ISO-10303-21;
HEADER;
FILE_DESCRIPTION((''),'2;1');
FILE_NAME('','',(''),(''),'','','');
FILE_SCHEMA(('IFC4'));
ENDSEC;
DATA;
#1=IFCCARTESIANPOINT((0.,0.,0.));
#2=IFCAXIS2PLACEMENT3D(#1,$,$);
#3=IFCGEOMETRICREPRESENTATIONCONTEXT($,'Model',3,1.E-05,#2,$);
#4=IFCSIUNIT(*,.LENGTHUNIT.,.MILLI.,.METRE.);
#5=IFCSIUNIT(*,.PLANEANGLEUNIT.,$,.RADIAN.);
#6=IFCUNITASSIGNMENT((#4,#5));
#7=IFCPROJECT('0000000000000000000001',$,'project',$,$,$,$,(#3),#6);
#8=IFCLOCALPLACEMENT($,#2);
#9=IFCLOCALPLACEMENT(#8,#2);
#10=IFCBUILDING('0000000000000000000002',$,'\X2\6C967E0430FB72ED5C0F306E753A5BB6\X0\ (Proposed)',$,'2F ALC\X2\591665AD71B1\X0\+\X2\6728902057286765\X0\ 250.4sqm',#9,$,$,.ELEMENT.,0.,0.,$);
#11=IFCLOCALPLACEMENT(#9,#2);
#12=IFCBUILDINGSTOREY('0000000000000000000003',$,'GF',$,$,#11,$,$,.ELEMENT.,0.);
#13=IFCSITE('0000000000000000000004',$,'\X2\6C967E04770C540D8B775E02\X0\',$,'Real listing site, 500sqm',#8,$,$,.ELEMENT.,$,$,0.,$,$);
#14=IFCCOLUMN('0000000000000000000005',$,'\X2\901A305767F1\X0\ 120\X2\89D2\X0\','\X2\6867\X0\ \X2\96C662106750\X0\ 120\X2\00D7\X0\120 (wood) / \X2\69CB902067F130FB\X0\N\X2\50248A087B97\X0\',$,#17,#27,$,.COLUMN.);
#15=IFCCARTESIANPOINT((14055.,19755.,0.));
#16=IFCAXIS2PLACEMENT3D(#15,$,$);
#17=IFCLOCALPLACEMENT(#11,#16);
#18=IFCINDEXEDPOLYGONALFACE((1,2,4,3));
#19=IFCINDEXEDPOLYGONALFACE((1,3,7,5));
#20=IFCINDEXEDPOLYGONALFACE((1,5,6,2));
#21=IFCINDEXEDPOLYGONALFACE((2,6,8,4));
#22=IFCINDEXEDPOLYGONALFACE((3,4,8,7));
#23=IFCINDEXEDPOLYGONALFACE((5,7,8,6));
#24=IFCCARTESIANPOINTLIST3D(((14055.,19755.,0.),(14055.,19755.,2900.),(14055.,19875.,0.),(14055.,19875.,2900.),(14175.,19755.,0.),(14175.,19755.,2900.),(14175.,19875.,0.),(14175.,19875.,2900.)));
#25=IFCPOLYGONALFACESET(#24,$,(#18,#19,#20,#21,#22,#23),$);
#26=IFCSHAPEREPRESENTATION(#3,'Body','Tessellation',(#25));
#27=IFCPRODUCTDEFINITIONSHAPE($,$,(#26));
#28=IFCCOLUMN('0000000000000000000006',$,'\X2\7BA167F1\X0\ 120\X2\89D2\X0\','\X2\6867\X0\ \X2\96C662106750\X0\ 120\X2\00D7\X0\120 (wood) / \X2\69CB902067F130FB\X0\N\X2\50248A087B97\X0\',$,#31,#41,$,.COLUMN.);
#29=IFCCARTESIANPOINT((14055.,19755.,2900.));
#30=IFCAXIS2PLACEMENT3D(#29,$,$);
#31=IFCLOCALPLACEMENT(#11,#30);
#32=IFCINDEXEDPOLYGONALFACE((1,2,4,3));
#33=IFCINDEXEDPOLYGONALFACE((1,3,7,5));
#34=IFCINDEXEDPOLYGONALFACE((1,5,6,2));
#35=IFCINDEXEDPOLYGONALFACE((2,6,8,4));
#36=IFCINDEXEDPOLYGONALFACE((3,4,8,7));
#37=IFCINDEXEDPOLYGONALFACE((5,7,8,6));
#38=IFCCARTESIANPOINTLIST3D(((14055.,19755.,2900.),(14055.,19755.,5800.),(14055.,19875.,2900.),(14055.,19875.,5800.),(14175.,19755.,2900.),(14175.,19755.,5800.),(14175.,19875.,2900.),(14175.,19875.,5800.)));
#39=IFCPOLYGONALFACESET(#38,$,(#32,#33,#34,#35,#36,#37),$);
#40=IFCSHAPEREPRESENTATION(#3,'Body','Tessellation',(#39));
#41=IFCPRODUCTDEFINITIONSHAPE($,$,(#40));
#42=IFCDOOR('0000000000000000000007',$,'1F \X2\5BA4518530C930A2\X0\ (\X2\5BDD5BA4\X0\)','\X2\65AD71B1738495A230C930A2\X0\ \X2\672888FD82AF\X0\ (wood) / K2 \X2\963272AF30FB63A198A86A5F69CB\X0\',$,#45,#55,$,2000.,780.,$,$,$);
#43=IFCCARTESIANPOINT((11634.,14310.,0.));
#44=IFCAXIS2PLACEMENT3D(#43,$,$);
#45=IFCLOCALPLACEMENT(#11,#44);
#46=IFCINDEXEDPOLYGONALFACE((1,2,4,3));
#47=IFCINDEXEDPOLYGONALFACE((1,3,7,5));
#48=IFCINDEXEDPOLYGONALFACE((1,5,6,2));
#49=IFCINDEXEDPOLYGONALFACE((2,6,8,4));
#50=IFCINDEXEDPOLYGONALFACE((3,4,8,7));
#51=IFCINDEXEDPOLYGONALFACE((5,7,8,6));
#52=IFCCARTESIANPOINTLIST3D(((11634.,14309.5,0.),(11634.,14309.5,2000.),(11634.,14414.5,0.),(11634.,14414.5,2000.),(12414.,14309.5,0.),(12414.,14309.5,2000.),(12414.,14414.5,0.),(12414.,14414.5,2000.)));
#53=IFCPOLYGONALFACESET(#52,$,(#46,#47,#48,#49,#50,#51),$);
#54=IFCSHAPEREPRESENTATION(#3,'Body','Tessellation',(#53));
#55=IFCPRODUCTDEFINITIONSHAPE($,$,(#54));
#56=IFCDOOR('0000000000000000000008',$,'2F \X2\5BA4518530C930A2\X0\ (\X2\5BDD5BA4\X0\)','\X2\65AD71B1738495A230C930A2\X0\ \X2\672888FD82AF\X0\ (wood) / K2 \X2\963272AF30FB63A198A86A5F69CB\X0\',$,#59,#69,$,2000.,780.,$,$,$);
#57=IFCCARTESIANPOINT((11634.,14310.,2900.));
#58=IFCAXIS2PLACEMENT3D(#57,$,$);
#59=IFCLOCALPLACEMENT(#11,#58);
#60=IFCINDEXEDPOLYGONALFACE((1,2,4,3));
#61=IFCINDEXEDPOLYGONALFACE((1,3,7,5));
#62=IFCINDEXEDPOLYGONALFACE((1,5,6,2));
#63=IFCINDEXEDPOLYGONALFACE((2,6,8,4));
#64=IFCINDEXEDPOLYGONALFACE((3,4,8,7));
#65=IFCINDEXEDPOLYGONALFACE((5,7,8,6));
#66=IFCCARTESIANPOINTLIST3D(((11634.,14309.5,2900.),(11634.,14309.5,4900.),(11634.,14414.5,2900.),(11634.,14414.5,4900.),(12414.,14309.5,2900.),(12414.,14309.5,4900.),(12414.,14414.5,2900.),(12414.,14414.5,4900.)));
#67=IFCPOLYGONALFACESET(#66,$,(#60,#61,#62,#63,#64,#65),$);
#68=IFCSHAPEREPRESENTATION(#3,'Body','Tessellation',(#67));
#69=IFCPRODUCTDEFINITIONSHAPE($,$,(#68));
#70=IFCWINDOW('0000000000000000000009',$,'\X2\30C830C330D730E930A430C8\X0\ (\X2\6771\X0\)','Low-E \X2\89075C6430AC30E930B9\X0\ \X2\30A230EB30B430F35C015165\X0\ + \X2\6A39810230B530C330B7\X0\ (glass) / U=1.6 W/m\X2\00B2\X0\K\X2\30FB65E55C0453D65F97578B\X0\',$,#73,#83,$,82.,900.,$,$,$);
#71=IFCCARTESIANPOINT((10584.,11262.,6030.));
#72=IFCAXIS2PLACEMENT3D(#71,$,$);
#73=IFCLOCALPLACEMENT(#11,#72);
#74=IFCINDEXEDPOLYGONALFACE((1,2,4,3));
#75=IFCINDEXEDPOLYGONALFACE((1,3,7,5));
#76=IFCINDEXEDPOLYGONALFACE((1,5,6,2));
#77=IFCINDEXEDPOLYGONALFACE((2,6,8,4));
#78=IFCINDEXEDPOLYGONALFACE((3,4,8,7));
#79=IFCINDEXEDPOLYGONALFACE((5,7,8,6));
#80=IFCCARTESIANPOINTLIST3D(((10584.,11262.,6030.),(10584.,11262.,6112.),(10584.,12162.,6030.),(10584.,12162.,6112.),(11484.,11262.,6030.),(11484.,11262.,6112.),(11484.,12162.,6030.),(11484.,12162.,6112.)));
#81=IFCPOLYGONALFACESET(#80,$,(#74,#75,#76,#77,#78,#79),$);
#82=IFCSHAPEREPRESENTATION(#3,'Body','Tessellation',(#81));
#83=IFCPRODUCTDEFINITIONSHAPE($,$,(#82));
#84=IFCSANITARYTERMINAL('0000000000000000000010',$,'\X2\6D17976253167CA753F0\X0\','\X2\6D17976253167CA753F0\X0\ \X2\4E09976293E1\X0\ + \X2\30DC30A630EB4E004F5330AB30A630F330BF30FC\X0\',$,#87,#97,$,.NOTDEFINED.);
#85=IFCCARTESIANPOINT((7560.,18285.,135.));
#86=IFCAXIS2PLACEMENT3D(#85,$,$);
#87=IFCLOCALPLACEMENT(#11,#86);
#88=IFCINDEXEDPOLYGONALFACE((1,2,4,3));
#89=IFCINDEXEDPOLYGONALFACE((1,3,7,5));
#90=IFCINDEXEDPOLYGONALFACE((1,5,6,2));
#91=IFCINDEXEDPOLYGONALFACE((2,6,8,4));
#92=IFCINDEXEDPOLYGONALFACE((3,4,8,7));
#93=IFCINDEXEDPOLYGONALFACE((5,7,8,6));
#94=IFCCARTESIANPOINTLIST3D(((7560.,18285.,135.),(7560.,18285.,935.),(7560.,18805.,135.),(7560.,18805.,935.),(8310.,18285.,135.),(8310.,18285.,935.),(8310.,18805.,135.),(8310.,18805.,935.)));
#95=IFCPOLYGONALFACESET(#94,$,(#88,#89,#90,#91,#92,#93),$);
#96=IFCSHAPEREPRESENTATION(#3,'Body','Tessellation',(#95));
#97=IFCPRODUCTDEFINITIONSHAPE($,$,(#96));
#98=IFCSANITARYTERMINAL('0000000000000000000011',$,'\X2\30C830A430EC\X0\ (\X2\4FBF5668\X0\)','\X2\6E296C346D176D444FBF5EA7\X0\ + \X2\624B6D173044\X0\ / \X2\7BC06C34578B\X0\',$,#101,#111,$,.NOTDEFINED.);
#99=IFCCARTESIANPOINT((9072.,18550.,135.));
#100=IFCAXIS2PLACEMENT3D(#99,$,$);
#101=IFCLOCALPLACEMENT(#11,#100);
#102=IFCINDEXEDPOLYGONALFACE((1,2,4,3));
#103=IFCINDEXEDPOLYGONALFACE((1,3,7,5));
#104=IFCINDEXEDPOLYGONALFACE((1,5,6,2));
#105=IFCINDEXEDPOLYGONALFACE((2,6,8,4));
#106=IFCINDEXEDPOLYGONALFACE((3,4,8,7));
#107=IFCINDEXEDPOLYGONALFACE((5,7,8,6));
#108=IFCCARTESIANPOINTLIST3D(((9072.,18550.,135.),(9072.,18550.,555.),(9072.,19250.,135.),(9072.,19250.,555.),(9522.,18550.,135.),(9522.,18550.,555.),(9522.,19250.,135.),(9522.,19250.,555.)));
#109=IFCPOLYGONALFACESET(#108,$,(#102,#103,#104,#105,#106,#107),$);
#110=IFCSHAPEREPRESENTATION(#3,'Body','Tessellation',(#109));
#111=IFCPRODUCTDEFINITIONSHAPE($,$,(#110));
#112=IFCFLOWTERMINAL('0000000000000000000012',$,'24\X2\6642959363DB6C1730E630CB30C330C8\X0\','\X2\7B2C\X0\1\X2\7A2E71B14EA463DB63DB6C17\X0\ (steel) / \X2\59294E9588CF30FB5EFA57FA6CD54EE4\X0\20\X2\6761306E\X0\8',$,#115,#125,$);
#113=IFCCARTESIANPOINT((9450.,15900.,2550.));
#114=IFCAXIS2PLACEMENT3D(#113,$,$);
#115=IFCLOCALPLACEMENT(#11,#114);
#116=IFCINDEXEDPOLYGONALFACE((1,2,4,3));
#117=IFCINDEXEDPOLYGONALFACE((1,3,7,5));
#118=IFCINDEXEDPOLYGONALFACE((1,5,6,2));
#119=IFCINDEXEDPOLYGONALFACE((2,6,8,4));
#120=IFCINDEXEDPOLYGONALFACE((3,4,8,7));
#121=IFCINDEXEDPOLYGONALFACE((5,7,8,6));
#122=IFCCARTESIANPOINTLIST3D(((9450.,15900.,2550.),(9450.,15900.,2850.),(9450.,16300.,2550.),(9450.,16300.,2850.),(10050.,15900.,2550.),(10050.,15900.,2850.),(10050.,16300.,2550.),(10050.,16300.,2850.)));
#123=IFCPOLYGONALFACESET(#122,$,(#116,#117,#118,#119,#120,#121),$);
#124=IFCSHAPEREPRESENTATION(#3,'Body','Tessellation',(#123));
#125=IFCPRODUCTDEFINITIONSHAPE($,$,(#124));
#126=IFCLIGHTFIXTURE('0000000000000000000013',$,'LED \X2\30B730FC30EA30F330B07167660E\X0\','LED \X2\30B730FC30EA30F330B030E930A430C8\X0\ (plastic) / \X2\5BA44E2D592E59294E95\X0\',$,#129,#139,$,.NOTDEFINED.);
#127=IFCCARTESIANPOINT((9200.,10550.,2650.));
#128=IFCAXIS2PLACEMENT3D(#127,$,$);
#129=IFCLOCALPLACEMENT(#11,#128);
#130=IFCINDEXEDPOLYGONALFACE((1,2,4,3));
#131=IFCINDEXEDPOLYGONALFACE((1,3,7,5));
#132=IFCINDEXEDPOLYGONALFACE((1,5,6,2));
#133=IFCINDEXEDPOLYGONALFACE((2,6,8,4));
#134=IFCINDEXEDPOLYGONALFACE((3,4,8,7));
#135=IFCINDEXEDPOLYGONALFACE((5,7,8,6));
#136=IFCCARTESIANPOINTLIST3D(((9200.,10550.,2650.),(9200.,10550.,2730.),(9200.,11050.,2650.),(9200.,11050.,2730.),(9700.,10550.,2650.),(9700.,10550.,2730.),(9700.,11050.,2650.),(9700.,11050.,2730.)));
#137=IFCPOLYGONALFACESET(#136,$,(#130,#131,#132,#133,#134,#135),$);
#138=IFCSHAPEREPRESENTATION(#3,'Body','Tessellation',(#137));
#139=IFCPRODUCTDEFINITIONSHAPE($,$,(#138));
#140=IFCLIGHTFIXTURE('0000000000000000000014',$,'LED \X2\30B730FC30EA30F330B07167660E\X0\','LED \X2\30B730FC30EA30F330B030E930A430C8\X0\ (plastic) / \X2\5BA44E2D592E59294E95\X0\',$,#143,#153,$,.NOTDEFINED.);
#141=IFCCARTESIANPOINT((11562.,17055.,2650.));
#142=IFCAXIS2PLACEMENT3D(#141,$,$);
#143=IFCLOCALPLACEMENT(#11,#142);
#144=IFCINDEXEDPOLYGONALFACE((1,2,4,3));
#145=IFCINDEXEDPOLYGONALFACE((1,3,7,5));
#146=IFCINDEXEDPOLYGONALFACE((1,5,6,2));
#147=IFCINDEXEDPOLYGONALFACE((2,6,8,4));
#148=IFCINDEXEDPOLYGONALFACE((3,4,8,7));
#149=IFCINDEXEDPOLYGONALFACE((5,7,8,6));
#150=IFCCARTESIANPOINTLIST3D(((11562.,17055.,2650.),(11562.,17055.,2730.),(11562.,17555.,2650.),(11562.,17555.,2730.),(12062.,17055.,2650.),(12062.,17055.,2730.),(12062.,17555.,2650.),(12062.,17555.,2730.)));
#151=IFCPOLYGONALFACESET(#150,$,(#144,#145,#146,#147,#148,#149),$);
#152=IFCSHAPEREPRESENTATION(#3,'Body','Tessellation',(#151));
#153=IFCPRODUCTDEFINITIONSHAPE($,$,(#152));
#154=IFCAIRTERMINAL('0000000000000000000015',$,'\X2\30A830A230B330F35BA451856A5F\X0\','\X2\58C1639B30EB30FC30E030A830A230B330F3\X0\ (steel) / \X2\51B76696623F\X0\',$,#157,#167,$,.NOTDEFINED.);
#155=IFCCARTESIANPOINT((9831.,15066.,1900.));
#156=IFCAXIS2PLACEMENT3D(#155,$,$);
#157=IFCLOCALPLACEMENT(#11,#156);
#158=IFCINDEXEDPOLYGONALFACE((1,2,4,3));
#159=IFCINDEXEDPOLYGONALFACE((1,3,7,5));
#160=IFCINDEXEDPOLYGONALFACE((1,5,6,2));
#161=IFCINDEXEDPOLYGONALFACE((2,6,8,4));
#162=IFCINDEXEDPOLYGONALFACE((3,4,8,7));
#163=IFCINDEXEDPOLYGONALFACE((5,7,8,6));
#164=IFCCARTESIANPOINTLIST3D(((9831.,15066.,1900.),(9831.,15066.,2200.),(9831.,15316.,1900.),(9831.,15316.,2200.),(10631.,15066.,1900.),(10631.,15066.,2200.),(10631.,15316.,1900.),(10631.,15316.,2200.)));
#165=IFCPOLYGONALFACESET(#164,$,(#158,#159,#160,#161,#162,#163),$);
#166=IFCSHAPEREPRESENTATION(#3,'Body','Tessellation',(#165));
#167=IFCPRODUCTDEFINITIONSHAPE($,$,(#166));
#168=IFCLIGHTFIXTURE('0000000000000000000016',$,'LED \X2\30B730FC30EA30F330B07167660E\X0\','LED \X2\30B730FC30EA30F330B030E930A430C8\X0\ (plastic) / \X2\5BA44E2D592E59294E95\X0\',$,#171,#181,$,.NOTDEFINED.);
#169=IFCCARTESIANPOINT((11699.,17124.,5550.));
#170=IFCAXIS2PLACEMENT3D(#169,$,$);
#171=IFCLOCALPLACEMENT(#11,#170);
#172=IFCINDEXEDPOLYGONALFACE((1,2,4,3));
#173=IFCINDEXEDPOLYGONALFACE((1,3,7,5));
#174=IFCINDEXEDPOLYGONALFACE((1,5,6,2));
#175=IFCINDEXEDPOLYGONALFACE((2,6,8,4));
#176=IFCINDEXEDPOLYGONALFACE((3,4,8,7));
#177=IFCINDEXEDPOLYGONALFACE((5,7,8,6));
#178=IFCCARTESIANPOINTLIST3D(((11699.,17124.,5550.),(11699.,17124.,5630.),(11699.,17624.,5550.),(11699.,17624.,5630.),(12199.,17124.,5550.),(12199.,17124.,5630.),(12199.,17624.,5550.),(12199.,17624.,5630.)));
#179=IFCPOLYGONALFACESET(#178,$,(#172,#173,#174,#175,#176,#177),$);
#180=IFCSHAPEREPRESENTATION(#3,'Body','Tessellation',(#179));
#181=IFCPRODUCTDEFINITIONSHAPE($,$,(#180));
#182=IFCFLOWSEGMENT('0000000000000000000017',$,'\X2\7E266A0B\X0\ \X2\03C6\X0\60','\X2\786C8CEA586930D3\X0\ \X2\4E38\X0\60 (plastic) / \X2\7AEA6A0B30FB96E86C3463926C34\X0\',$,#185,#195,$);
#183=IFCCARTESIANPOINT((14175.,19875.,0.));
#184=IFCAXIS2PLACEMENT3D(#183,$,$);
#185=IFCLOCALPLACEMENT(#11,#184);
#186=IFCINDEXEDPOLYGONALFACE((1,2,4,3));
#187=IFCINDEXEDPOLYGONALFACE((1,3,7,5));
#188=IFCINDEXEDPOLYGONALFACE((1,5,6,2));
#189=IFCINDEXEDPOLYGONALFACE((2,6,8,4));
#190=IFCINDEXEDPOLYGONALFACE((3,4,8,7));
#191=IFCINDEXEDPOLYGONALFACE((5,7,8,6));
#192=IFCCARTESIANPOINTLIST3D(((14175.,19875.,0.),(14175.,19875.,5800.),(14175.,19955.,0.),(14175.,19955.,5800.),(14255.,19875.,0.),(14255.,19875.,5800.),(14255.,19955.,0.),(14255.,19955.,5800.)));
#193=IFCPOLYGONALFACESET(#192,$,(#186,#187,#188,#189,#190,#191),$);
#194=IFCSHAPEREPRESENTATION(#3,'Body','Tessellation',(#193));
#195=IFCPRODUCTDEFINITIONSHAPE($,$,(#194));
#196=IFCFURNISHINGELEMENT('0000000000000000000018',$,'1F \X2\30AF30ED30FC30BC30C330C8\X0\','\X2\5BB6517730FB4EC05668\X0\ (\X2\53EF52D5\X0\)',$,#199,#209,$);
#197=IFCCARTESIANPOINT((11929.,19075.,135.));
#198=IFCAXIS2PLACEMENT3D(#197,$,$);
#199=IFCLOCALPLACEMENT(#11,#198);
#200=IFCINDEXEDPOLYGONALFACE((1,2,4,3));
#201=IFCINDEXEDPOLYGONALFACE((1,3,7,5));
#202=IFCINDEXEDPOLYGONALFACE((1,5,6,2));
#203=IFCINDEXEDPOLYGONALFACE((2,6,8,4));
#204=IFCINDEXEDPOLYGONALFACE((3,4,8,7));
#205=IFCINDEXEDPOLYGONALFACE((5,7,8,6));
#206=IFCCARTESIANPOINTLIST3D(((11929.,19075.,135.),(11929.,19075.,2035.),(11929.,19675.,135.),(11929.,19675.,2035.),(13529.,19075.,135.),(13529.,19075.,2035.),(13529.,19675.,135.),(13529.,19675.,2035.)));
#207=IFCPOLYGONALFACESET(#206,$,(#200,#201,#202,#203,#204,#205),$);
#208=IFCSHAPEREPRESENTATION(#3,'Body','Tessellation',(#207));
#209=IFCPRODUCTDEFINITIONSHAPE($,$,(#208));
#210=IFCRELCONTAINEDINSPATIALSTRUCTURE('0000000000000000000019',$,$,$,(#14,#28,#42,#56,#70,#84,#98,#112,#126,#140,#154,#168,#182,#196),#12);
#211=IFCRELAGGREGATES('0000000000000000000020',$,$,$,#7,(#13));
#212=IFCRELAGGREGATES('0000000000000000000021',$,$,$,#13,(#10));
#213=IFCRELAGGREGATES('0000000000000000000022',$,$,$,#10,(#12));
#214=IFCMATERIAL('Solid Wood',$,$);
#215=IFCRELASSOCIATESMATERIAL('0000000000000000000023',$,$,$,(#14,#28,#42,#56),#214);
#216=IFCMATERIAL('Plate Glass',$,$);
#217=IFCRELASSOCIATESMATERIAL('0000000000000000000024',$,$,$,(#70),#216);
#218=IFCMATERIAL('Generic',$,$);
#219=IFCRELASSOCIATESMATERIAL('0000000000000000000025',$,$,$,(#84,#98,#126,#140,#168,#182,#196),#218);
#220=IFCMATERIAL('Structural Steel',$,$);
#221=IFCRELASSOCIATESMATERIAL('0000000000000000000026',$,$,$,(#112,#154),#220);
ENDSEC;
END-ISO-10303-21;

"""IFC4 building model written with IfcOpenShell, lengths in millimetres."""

from ifc_helpers import new_model, si_unit, frame, frame_2d, origin, place, context, project, spatial, rectangle, extrude, material, element, save


model = new_model("IFC4")

# Units and contexts
model_context = context("Model", 3, precision=1e-05, world=origin())
ifc_project = project(units=[si_unit("LENGTHUNIT", "METRE", prefix="MILLI"), si_unit("PLANEANGLEUNIT", "RADIAN")], contexts=[model_context])

# Site, building, storey
site_placement = place(None, origin())
site = spatial("IfcSite", under=ifc_project, at=site_placement, Name="沖縄県名護市", ObjectType="Real listing site, 500sqm", CompositionType="ELEMENT", RefElevation=0.0)
building_placement = place(site_placement, origin())
building = spatial("IfcBuilding", under=site, at=building_placement, Name="沖縄・狭小の町家 (Proposed)", ObjectType="2F ALC外断熱+木造在来 250.4sqm", CompositionType="ELEMENT", ElevationOfRefHeight=0.0, ElevationOfTerrain=0.0)
storey_placement = place(building_placement, origin())
storey = spatial("IfcBuildingStorey", under=building, at=storey_placement, Name="GF", CompositionType="ELEMENT", Elevation=0.0)

# Columns
ifc_material_1 = material(Name="Solid Wood")
column_1_placement = place(storey_placement, frame((14055.0, 19755.0, 0.0)))
element("IfcColumn", 1, at=column_1_placement, inside=storey, material=ifc_material_1, Name="通し柱 120角", Description="桧 集成材 120×120 (wood) / 構造柱・N値計算", PredefinedType="COLUMN", context=model_context, shape_type="SweptSolid", body=[
    extrude(rectangle(XDim=120.0, YDim=120.0, at=frame_2d((60.0, 60.0))), frame((14055.0, 19755.0, 0.0)), (0.0, 0.0, 1.0), 2900.0),
])
column_2_placement = place(storey_placement, frame((14055.0, 19755.0, 2900.0)))
element("IfcColumn", 2, at=column_2_placement, inside=storey, material=ifc_material_1, Name="管柱 120角", Description="桧 集成材 120×120 (wood) / 構造柱・N値計算", PredefinedType="COLUMN", context=model_context, shape_type="SweptSolid", body=[
    extrude(rectangle(XDim=120.0, YDim=120.0, at=frame_2d((60.0, 60.0))), frame((14055.0, 19755.0, 2900.0)), (0.0, 0.0, 1.0), 2900.0),
])

# Door
door_1_placement = place(storey_placement, frame((11634.0, 14310.0, 0.0)))
element("IfcDoor", 3, at=door_1_placement, inside=storey, material=ifc_material_1, Name="1F 室内ドア (寝室)", Description="断熱玄関ドア 木製芯 (wood) / K2 防犯・採風機構", OverallHeight=2000.0, OverallWidth=780.0, context=model_context, shape_type="SweptSolid", body=[
    extrude(rectangle(XDim=780.0, YDim=105.0, at=frame_2d((390.0, 52.0))), frame((11634.0, 14310.0, 0.0)), (0.0, 0.0, 1.0), 2000.0),
])

# Door
door_2_placement = place(storey_placement, frame((11634.0, 14310.0, 2900.0)))
element("IfcDoor", 4, at=door_2_placement, inside=storey, material=ifc_material_1, Name="2F 室内ドア (寝室)", Description="断熱玄関ドア 木製芯 (wood) / K2 防犯・採風機構", OverallHeight=2000.0, OverallWidth=780.0, context=model_context, shape_type="SweptSolid", body=[
    extrude(rectangle(XDim=780.0, YDim=105.0, at=frame_2d((390.0, 52.0))), frame((11634.0, 14310.0, 2900.0)), (0.0, 0.0, 1.0), 2000.0),
])

# Window
ifc_material_2 = material(Name="Plate Glass")
window_placement = place(storey_placement, frame((10584.0, 11262.0, 6030.0)))
element("IfcWindow", 5, at=window_placement, inside=storey, material=ifc_material_2, Name="トップライト (東)", Description="Low-E 複層ガラス アルゴン封入 + 樹脂サッシ (glass) / U=1.6 W/m²K・日射取得型", OverallHeight=82.0, OverallWidth=900.0, context=model_context, shape_type="SweptSolid", body=[
    extrude(rectangle(XDim=900.0, YDim=900.0, at=frame_2d((450.0, 450.0))), frame((10584.0, 11262.0, 6030.0)), (0.0, 0.0, 1.0), 82.0),
])

# Sanitary terminals
ifc_material_3 = material(Name="Generic")
sanitary_terminal_1_placement = place(storey_placement, frame((7560.0, 18285.0, 135.0)))
element("IfcSanitaryTerminal", 6, at=sanitary_terminal_1_placement, inside=storey, material=ifc_material_3, Name="洗面化粧台", Description="洗面化粧台 三面鏡 + ボウル一体カウンター", PredefinedType="NOTDEFINED", context=model_context, shape_type="SweptSolid", body=[
    extrude(rectangle(XDim=750.0, YDim=520.0, at=frame_2d((375.0, 260.0))), frame((7560.0, 18285.0, 135.0)), (0.0, 0.0, 1.0), 800.0),
])
sanitary_terminal_2_placement = place(storey_placement, frame((9072.0, 18550.0, 135.0)))
element("IfcSanitaryTerminal", 7, at=sanitary_terminal_2_placement, inside=storey, material=ifc_material_3, Name="トイレ (便器)", Description="温水洗浄便座 + 手洗い / 節水型", PredefinedType="NOTDEFINED", context=model_context, shape_type="SweptSolid", body=[
    extrude(rectangle(XDim=450.0, YDim=700.0, at=frame_2d((225.0, 350.0))), frame((9072.0, 18550.0, 135.0)), (0.0, 0.0, 1.0), 420.0),
])

# Flow terminal
ifc_material_4 = material(Name="Structural Steel")
flow_terminal_placement = place(storey_placement, frame((9450.0, 15900.0, 2550.0)))
element("IfcFlowTerminal", 8, at=flow_terminal_placement, inside=storey, material=ifc_material_4, Name="24時間換気ユニット", Description="第1種熱交換換気 (steel) / 天井裏・建基法令20条の8", context=model_context, shape_type="SweptSolid", body=[
    extrude(rectangle(XDim=600.0, YDim=400.0, at=frame_2d((300.0, 200.0))), frame((9450.0, 15900.0, 2550.0)), (0.0, 0.0, 1.0), 300.0),
])

# Light fixtures
light_fixture_1_placement = place(storey_placement, frame((9200.0, 10550.0, 2650.0)))
element("IfcLightFixture", 9, at=light_fixture_1_placement, inside=storey, material=ifc_material_3, Name="LED シーリング照明", Description="LED シーリングライト (plastic) / 室中央天井", PredefinedType="NOTDEFINED", context=model_context, shape_type="SweptSolid", body=[
    extrude(rectangle(XDim=500.0, YDim=500.0, at=frame_2d((250.0, 250.0))), frame((9200.0, 10550.0, 2650.0)), (0.0, 0.0, 1.0), 80.0),
])
light_fixture_2_placement = place(storey_placement, frame((11562.0, 17055.0, 2650.0)))
element("IfcLightFixture", 10, at=light_fixture_2_placement, inside=storey, material=ifc_material_3, Name="LED シーリング照明", Description="LED シーリングライト (plastic) / 室中央天井", PredefinedType="NOTDEFINED", context=model_context, shape_type="SweptSolid", body=[
    extrude(rectangle(XDim=500.0, YDim=500.0, at=frame_2d((250.0, 250.0))), frame((11562.0, 17055.0, 2650.0)), (0.0, 0.0, 1.0), 80.0),
])

# Air terminal
air_terminal_placement = place(storey_placement, frame((9831.0, 15066.0, 1900.0)))
element("IfcAirTerminal", 11, at=air_terminal_placement, inside=storey, material=ifc_material_4, Name="エアコン室内機", Description="壁掛ルームエアコン (steel) / 冷暖房", PredefinedType="NOTDEFINED", context=model_context, shape_type="SweptSolid", body=[
    extrude(rectangle(XDim=800.0, YDim=250.0, at=frame_2d((400.0, 125.0))), frame((9831.0, 15066.0, 1900.0)), (0.0, 0.0, 1.0), 300.0),
])

# Light fixture
light_fixture_3_placement = place(storey_placement, frame((11699.0, 17124.0, 5550.0)))
element("IfcLightFixture", 12, at=light_fixture_3_placement, inside=storey, material=ifc_material_3, Name="LED シーリング照明", Description="LED シーリングライト (plastic) / 室中央天井", PredefinedType="NOTDEFINED", context=model_context, shape_type="SweptSolid", body=[
    extrude(rectangle(XDim=500.0, YDim=500.0, at=frame_2d((250.0, 250.0))), frame((11699.0, 17124.0, 5550.0)), (0.0, 0.0, 1.0), 80.0),
])

# Flow segment
flow_segment_placement = place(storey_placement, frame((14175.0, 19875.0, 0.0)))
element("IfcFlowSegment", 13, at=flow_segment_placement, inside=storey, material=ifc_material_3, Name="縦樋 φ60", Description="硬質塩ビ 丸60 (plastic) / 竪樋・雨水排水", context=model_context, shape_type="SweptSolid", body=[
    extrude(rectangle(XDim=80.0, YDim=80.0, at=frame_2d((40.0, 40.0))), frame((14175.0, 19875.0, 0.0)), (0.0, 0.0, 1.0), 5800.0),
])

# Furnishing element
furnishing_1_placement = place(storey_placement, frame((11929.0, 19075.0, 135.0)))
element("IfcFurnishingElement", 14, at=furnishing_1_placement, inside=storey, material=ifc_material_3, Name="1F クローゼット", Description="家具・什器 (可動)", context=model_context, shape_type="SweptSolid", body=[
    extrude(rectangle(XDim=1600.0, YDim=600.0, at=frame_2d((800.0, 300.0))), frame((11929.0, 19075.0, 135.0)), (0.0, 0.0, 1.0), 1900.0),
])

save(model, "model.ifc")
